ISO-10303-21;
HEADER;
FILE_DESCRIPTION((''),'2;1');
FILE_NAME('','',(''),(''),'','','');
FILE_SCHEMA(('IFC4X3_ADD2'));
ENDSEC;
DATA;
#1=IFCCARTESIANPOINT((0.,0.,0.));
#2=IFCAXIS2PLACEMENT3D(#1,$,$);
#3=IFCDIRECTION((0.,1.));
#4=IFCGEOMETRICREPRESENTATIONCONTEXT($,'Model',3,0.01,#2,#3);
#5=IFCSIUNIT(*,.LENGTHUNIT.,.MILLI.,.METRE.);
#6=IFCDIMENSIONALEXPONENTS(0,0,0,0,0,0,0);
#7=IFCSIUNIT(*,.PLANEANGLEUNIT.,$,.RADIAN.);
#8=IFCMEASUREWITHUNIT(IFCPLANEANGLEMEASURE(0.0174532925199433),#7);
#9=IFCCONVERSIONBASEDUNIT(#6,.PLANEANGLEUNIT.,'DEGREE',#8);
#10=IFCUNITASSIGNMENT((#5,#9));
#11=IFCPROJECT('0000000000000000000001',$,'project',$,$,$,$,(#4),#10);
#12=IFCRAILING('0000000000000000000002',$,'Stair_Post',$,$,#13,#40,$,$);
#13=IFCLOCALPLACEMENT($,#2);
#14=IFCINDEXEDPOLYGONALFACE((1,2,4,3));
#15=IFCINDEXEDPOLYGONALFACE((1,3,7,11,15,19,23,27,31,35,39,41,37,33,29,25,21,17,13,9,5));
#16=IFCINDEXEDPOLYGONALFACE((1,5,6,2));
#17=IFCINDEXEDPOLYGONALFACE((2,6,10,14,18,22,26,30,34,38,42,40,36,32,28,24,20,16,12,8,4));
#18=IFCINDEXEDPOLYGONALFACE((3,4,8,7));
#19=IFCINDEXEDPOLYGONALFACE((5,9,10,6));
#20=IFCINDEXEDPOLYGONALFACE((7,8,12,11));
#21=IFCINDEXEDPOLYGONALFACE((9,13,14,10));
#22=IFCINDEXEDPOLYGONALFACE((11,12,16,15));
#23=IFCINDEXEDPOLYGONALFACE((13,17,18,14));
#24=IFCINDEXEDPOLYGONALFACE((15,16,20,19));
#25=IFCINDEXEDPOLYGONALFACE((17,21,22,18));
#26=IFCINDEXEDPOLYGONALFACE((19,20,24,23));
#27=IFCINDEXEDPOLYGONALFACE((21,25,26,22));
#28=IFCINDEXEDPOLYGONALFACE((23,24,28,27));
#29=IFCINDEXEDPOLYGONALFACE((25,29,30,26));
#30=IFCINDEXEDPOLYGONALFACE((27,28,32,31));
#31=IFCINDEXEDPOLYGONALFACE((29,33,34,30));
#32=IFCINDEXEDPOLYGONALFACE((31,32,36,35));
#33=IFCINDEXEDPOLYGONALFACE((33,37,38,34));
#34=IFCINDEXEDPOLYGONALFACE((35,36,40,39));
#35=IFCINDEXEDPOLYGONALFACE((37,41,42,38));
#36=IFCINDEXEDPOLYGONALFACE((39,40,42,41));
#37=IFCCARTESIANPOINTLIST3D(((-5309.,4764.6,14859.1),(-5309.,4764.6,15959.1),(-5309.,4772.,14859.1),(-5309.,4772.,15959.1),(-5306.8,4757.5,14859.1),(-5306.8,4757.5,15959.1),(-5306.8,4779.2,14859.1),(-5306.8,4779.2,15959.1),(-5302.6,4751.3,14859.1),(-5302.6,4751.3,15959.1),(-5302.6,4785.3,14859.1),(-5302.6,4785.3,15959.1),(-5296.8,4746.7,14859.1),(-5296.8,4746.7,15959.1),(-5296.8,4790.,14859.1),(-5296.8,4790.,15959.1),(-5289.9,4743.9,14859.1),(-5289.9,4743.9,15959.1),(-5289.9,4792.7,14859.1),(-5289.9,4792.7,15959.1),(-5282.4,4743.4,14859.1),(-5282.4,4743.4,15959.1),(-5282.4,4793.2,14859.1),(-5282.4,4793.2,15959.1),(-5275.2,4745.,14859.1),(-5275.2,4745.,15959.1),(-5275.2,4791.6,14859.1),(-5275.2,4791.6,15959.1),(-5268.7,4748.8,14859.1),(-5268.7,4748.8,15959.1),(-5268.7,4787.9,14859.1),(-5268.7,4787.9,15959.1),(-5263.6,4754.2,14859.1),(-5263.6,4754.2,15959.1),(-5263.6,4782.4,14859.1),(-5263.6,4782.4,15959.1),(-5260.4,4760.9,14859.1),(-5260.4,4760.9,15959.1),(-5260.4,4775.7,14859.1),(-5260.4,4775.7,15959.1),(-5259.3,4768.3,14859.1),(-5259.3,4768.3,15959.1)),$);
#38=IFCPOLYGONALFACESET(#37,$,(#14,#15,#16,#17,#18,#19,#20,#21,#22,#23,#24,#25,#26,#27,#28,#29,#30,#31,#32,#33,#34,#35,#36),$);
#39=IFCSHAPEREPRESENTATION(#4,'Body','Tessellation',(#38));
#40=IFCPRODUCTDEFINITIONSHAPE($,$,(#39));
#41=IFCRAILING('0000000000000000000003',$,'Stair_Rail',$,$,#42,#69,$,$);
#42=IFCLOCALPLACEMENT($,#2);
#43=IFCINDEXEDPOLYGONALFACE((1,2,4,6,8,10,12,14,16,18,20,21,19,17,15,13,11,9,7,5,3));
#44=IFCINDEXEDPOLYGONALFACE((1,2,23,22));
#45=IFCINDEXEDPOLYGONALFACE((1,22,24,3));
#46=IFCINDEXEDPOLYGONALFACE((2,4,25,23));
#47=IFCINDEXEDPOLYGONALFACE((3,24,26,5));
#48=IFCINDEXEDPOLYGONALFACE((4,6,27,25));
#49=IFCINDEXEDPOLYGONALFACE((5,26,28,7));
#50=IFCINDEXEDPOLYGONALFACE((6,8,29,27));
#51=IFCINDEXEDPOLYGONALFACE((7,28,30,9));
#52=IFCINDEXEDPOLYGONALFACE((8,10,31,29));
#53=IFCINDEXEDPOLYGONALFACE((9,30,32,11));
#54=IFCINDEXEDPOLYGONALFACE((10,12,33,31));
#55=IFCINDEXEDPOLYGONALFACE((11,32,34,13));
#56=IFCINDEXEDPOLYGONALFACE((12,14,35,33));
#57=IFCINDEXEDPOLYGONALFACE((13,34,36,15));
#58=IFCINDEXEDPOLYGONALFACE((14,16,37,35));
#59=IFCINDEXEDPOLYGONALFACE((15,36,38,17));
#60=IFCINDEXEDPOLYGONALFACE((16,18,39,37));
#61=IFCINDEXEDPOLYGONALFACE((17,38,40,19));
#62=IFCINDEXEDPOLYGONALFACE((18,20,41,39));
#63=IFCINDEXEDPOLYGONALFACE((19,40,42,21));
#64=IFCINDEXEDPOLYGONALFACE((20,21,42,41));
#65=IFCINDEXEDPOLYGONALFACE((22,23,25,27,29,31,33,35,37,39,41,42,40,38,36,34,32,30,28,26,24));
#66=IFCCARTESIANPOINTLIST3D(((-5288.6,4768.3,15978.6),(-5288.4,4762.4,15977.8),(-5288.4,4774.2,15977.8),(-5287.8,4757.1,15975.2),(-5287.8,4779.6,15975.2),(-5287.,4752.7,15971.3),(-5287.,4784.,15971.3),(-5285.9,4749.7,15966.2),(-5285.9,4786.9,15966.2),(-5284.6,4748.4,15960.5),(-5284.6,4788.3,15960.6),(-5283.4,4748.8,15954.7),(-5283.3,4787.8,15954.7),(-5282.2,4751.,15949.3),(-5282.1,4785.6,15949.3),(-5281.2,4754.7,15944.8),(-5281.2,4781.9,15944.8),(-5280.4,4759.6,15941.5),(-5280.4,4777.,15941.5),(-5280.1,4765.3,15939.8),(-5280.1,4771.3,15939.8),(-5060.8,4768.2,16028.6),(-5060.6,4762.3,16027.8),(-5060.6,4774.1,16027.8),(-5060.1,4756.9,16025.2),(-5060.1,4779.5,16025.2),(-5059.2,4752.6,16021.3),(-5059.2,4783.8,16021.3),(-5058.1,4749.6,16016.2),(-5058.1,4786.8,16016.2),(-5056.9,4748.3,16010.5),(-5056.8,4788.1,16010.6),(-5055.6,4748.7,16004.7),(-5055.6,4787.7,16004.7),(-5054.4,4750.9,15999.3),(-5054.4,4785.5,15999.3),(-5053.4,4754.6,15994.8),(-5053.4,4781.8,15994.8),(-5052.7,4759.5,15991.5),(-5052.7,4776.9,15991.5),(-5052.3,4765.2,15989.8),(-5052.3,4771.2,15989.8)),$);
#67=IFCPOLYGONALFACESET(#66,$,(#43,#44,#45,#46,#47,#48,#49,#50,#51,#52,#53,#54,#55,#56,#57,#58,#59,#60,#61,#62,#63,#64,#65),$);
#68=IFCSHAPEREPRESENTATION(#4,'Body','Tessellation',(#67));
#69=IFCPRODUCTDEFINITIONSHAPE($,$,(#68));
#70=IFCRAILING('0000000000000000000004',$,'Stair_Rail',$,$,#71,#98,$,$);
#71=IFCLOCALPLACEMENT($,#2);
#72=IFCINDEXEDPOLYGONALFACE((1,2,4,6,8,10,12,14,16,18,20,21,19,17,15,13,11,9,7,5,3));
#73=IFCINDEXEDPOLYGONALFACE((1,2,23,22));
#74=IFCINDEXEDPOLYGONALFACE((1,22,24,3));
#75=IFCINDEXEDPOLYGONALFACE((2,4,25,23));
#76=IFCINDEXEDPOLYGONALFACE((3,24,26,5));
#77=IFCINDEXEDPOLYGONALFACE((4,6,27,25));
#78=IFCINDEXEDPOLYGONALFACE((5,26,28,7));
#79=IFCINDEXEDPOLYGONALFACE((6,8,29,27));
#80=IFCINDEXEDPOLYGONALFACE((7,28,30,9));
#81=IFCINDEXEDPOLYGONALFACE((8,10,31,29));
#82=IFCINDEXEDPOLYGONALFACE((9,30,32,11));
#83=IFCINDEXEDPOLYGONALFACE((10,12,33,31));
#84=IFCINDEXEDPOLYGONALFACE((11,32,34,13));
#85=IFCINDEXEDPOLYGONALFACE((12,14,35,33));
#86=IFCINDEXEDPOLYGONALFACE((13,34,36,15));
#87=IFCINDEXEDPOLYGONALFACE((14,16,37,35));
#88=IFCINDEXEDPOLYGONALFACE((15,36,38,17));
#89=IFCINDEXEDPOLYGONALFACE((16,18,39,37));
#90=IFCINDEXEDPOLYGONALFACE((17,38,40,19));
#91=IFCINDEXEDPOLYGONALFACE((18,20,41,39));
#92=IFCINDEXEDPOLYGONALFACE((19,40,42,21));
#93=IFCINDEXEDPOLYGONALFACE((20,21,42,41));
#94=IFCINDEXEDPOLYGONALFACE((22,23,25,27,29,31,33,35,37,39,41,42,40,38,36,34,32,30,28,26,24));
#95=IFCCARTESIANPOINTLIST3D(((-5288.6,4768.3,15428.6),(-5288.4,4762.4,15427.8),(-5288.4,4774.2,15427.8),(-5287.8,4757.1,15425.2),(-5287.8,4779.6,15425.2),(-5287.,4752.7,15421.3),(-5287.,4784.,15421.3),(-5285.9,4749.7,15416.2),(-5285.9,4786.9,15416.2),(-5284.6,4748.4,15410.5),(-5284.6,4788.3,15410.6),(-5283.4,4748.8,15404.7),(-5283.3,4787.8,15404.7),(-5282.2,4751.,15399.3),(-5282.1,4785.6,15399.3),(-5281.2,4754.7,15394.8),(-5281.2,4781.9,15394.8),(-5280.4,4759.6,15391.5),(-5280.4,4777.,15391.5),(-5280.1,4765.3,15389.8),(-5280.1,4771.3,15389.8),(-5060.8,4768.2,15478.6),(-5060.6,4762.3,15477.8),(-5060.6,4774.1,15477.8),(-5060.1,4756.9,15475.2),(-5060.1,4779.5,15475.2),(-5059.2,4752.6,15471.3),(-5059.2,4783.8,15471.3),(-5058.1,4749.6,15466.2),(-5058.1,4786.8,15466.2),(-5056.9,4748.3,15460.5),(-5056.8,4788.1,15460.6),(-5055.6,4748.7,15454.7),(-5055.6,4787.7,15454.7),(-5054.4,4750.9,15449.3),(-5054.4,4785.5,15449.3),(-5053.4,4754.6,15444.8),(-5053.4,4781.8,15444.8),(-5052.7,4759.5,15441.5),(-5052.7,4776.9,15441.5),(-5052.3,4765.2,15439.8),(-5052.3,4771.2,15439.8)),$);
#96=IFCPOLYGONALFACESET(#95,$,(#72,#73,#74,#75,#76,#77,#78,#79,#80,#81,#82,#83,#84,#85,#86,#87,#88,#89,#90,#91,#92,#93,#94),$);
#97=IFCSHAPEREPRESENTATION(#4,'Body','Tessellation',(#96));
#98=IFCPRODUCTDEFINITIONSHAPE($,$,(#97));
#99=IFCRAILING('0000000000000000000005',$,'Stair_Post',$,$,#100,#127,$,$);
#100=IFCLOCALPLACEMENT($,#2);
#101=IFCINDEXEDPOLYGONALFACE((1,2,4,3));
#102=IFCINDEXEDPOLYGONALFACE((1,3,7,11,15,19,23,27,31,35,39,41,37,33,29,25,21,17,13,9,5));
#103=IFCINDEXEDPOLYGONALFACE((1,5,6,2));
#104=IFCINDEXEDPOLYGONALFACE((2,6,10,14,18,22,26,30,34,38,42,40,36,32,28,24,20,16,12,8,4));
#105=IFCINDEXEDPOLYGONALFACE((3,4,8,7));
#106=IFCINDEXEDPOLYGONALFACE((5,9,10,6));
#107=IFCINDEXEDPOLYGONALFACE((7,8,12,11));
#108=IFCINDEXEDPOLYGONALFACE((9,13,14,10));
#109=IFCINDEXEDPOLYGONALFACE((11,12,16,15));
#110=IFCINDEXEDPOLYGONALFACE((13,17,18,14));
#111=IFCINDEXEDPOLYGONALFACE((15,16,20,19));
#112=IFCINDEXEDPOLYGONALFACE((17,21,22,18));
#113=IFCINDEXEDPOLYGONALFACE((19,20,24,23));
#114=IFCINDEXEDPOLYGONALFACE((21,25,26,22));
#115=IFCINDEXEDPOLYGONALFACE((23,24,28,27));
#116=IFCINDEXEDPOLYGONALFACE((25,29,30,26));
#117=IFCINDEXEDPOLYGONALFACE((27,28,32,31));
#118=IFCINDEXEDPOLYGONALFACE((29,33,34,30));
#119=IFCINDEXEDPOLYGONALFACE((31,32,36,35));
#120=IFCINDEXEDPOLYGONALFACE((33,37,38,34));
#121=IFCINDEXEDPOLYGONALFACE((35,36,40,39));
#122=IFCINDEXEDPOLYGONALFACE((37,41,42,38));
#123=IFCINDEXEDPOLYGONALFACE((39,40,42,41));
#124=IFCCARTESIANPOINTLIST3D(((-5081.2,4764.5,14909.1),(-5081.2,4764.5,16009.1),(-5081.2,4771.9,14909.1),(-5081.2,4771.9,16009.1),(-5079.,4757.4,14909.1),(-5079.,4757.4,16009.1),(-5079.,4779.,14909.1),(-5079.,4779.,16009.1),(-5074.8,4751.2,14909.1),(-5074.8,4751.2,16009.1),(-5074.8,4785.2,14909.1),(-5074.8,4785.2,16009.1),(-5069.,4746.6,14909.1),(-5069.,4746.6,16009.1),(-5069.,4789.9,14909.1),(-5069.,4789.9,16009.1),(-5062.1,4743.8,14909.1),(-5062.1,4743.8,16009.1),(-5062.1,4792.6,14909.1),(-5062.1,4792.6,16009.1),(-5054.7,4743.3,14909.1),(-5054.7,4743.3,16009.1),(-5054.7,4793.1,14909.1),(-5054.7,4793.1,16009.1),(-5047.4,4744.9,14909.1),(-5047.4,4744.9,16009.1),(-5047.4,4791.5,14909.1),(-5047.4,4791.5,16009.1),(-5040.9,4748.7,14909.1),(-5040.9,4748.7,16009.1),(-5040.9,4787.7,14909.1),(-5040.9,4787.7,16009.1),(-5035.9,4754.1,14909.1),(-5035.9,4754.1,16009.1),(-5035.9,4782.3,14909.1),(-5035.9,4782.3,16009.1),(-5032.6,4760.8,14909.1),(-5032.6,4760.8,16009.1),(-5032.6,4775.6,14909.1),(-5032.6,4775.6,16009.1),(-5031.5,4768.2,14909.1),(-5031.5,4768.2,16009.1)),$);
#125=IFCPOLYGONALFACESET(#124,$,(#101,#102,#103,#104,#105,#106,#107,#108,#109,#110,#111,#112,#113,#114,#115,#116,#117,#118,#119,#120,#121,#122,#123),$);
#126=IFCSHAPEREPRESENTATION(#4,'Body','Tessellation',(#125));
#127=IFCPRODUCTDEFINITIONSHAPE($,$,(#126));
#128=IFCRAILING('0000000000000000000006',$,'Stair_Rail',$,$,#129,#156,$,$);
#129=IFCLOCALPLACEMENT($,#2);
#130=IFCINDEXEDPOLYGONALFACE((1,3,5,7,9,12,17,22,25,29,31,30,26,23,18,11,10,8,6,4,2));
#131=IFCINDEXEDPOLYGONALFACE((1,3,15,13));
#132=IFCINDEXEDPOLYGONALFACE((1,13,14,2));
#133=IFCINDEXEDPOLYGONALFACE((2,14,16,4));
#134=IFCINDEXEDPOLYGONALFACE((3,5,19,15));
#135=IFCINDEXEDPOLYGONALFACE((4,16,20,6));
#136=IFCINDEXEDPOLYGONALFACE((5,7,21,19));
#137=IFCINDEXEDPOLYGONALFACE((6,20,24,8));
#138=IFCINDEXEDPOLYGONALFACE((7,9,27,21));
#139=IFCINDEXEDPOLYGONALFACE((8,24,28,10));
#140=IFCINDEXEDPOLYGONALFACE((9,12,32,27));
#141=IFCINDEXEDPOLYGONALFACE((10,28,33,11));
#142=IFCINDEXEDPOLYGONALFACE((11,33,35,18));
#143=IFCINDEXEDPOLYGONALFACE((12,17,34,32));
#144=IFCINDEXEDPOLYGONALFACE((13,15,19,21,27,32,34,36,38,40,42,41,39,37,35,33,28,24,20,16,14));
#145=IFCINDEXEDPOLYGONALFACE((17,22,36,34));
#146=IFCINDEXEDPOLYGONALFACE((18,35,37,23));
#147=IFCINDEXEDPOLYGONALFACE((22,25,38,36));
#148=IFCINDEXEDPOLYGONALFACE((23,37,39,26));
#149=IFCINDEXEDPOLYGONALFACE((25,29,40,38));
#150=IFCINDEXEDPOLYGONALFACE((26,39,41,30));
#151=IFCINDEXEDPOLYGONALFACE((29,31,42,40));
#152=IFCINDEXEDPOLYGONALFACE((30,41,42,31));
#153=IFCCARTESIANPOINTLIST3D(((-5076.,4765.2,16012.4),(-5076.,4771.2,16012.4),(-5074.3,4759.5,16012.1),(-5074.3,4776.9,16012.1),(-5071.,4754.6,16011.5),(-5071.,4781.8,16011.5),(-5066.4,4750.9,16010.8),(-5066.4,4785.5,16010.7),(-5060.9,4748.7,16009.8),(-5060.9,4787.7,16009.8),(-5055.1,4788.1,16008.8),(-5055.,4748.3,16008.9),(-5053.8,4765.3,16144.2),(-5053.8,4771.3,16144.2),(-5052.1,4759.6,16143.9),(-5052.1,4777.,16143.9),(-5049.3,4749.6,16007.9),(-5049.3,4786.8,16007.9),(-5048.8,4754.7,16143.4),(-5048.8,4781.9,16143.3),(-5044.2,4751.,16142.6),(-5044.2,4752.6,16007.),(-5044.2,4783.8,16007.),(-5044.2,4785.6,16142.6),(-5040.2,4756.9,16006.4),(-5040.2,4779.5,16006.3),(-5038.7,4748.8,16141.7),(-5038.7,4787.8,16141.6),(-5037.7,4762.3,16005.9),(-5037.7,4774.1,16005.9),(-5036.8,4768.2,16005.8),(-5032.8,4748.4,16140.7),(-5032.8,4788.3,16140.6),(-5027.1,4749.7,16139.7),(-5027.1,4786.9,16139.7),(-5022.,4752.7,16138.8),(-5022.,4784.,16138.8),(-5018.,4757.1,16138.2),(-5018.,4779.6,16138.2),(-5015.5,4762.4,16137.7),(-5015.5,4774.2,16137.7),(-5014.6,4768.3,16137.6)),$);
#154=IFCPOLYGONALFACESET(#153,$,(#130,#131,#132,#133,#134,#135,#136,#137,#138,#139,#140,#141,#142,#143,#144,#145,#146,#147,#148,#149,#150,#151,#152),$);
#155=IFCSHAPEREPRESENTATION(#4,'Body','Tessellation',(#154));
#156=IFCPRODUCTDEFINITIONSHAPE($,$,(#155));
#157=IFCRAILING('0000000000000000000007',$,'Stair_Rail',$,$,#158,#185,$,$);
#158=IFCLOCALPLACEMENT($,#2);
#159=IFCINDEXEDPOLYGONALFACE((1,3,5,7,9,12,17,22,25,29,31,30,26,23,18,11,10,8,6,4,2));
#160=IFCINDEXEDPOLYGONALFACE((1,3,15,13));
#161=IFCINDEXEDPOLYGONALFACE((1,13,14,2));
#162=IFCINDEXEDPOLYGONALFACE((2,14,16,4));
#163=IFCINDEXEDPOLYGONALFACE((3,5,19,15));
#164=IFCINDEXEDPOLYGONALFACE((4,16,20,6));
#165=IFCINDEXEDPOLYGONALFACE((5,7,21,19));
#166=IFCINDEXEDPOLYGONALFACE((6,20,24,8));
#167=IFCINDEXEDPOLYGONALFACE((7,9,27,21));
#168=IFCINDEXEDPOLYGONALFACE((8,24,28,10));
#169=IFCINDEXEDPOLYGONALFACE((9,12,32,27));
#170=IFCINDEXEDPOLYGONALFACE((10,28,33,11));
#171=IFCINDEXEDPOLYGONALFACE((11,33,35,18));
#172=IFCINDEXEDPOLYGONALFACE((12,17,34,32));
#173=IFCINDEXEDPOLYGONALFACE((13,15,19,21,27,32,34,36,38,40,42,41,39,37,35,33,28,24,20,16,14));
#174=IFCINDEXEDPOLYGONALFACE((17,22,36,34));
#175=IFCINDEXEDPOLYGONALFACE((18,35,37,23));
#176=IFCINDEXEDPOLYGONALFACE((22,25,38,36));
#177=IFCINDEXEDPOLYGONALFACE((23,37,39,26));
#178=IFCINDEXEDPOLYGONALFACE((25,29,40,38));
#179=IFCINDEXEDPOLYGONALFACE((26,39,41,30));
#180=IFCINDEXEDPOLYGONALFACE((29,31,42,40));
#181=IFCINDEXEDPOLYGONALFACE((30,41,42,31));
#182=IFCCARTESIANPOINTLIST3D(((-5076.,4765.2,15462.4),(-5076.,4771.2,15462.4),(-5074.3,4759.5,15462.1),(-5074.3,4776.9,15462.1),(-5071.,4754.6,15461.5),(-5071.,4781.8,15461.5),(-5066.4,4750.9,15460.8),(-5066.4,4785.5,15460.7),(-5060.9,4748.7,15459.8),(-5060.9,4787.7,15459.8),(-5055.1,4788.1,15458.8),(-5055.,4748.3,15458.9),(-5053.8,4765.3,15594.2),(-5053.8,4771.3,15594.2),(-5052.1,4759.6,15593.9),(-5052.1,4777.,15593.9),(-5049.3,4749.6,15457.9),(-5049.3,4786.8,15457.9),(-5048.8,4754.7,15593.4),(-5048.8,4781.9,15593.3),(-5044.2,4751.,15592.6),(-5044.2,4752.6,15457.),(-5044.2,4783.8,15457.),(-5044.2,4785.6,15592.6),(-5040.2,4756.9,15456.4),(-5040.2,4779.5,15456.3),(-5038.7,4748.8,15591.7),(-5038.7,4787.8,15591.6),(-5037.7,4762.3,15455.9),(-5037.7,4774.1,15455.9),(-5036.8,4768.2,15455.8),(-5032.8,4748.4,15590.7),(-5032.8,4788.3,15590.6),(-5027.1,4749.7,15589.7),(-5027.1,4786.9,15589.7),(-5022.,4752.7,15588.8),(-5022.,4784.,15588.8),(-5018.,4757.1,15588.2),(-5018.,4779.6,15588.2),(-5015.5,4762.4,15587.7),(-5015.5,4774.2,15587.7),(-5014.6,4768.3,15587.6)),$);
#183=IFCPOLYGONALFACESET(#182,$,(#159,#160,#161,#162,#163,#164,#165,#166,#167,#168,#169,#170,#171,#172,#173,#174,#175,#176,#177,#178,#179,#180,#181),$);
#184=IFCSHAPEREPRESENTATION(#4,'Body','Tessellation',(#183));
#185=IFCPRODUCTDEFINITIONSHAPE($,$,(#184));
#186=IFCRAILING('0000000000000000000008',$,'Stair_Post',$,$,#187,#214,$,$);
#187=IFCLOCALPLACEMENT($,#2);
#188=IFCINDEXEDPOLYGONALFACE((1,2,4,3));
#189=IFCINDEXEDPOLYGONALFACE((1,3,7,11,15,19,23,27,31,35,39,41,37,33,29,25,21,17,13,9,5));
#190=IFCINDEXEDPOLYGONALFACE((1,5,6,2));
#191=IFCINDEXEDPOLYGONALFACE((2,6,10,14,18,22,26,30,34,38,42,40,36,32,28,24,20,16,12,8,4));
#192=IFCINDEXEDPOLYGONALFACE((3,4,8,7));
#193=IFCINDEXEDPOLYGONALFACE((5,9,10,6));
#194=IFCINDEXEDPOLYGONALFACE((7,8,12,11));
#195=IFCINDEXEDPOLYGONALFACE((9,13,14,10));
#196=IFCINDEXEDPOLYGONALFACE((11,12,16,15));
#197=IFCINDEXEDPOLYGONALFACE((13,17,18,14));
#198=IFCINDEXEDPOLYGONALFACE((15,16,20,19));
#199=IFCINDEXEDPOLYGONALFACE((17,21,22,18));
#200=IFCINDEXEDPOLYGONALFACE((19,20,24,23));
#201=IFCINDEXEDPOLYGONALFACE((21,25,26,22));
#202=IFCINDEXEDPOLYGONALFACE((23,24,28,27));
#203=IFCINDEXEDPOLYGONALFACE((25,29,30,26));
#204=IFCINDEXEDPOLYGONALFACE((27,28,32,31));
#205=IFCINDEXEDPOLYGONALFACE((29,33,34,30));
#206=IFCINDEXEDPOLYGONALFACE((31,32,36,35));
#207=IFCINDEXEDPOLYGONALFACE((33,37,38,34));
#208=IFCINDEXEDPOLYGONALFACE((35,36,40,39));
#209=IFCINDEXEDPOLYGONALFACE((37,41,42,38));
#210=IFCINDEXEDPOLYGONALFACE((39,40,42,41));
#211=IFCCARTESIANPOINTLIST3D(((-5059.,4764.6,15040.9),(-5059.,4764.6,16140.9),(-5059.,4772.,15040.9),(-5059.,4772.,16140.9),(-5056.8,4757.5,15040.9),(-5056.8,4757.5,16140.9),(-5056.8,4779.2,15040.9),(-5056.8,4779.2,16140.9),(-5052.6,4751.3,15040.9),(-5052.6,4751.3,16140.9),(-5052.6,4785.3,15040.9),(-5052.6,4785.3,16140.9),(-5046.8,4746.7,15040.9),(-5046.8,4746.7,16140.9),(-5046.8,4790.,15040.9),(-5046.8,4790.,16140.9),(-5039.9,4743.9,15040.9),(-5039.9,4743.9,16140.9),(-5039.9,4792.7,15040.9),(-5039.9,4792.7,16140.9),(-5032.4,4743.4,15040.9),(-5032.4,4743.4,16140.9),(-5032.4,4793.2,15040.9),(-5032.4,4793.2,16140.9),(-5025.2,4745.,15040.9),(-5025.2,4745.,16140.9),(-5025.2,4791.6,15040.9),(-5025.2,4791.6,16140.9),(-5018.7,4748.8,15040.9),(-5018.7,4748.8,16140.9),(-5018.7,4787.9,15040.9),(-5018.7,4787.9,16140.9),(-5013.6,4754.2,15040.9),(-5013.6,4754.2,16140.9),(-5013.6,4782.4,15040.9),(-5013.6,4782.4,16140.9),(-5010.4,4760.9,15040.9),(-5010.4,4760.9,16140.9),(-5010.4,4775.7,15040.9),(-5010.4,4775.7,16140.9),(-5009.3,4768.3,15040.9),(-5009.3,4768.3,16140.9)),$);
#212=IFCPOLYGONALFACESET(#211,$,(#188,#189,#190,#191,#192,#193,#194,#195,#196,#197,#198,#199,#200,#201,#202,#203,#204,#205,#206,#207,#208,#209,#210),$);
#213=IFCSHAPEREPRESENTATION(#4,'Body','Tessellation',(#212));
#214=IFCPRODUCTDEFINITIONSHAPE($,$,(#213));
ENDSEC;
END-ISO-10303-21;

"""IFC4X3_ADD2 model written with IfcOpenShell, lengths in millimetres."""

from ifc_helpers import new_model, entity, si_unit, converted_unit, direction, frame, origin, context, project, circle, extrude, element, save


model = new_model("IFC4X3_ADD2")

# Units and contexts
model_context = context("Model", 3, precision=0.01, world=origin(), true_north=direction((0.0, 1.0)))
ifc_project = project(units=[si_unit("LENGTHUNIT", "METRE", prefix="MILLI"), converted_unit("PLANEANGLEUNIT", "DEGREE", entity("IfcPlaneAngleMeasure", 0.0174532925199433), si_unit("PLANEANGLEUNIT", "RADIAN"), dimensions=[0, 0, 0, 0, 0, 0, 0])], contexts=[model_context])

# Railings
element("IfcRailing", 1, Name="Stair_Post", context=model_context, shape_type="SweptSolid", body=[
    extrude(circle(Radius=25.0), frame((-5284.3, 4768.3, 14859.1)), (0.0, 0.0, 1.0), 1100.0),
])
element("IfcRailing", 2, Name="Stair_Rail", context=model_context, shape_type="SweptSolid", body=[
    entity("IfcSweptDiskSolid", entity("IfcPolyline", [entity("IfcCartesianPoint", [-5284.3, 4768.3, 15959.1]), entity("IfcCartesianPoint", [-5056.5, 4768.2, 16009.1])]), 20.0),
])
element("IfcRailing", 3, Name="Stair_Rail", context=model_context, shape_type="SweptSolid", body=[
    entity("IfcSweptDiskSolid", entity("IfcPolyline", [entity("IfcCartesianPoint", [-5284.3, 4768.3, 15409.1]), entity("IfcCartesianPoint", [-5056.5, 4768.2, 15459.1])]), 20.0),
])
element("IfcRailing", 4, Name="Stair_Post", context=model_context, shape_type="SweptSolid", body=[
    extrude(circle(Radius=25.0), frame((-5056.5, 4768.2, 14909.1)), (0.0, 0.0, 1.0), 1100.0),
])
element("IfcRailing", 5, Name="Stair_Rail", context=model_context, shape_type="SweptSolid", body=[
    entity("IfcSweptDiskSolid", entity("IfcPolyline", [entity("IfcCartesianPoint", [-5056.5, 4768.2, 16009.1]), entity("IfcCartesianPoint", [-5034.3, 4768.3, 16140.9])]), 20.0),
])
element("IfcRailing", 6, Name="Stair_Rail", context=model_context, shape_type="SweptSolid", body=[
    entity("IfcSweptDiskSolid", entity("IfcPolyline", [entity("IfcCartesianPoint", [-5056.5, 4768.2, 15459.1]), entity("IfcCartesianPoint", [-5034.3, 4768.3, 15590.9])]), 20.0),
])
element("IfcRailing", 7, Name="Stair_Post", context=model_context, shape_type="SweptSolid", body=[
    extrude(circle(Radius=25.0), frame((-5034.3, 4768.3, 15040.9)), (0.0, 0.0, 1.0), 1100.0),
])

save(model, "model.ifc")
